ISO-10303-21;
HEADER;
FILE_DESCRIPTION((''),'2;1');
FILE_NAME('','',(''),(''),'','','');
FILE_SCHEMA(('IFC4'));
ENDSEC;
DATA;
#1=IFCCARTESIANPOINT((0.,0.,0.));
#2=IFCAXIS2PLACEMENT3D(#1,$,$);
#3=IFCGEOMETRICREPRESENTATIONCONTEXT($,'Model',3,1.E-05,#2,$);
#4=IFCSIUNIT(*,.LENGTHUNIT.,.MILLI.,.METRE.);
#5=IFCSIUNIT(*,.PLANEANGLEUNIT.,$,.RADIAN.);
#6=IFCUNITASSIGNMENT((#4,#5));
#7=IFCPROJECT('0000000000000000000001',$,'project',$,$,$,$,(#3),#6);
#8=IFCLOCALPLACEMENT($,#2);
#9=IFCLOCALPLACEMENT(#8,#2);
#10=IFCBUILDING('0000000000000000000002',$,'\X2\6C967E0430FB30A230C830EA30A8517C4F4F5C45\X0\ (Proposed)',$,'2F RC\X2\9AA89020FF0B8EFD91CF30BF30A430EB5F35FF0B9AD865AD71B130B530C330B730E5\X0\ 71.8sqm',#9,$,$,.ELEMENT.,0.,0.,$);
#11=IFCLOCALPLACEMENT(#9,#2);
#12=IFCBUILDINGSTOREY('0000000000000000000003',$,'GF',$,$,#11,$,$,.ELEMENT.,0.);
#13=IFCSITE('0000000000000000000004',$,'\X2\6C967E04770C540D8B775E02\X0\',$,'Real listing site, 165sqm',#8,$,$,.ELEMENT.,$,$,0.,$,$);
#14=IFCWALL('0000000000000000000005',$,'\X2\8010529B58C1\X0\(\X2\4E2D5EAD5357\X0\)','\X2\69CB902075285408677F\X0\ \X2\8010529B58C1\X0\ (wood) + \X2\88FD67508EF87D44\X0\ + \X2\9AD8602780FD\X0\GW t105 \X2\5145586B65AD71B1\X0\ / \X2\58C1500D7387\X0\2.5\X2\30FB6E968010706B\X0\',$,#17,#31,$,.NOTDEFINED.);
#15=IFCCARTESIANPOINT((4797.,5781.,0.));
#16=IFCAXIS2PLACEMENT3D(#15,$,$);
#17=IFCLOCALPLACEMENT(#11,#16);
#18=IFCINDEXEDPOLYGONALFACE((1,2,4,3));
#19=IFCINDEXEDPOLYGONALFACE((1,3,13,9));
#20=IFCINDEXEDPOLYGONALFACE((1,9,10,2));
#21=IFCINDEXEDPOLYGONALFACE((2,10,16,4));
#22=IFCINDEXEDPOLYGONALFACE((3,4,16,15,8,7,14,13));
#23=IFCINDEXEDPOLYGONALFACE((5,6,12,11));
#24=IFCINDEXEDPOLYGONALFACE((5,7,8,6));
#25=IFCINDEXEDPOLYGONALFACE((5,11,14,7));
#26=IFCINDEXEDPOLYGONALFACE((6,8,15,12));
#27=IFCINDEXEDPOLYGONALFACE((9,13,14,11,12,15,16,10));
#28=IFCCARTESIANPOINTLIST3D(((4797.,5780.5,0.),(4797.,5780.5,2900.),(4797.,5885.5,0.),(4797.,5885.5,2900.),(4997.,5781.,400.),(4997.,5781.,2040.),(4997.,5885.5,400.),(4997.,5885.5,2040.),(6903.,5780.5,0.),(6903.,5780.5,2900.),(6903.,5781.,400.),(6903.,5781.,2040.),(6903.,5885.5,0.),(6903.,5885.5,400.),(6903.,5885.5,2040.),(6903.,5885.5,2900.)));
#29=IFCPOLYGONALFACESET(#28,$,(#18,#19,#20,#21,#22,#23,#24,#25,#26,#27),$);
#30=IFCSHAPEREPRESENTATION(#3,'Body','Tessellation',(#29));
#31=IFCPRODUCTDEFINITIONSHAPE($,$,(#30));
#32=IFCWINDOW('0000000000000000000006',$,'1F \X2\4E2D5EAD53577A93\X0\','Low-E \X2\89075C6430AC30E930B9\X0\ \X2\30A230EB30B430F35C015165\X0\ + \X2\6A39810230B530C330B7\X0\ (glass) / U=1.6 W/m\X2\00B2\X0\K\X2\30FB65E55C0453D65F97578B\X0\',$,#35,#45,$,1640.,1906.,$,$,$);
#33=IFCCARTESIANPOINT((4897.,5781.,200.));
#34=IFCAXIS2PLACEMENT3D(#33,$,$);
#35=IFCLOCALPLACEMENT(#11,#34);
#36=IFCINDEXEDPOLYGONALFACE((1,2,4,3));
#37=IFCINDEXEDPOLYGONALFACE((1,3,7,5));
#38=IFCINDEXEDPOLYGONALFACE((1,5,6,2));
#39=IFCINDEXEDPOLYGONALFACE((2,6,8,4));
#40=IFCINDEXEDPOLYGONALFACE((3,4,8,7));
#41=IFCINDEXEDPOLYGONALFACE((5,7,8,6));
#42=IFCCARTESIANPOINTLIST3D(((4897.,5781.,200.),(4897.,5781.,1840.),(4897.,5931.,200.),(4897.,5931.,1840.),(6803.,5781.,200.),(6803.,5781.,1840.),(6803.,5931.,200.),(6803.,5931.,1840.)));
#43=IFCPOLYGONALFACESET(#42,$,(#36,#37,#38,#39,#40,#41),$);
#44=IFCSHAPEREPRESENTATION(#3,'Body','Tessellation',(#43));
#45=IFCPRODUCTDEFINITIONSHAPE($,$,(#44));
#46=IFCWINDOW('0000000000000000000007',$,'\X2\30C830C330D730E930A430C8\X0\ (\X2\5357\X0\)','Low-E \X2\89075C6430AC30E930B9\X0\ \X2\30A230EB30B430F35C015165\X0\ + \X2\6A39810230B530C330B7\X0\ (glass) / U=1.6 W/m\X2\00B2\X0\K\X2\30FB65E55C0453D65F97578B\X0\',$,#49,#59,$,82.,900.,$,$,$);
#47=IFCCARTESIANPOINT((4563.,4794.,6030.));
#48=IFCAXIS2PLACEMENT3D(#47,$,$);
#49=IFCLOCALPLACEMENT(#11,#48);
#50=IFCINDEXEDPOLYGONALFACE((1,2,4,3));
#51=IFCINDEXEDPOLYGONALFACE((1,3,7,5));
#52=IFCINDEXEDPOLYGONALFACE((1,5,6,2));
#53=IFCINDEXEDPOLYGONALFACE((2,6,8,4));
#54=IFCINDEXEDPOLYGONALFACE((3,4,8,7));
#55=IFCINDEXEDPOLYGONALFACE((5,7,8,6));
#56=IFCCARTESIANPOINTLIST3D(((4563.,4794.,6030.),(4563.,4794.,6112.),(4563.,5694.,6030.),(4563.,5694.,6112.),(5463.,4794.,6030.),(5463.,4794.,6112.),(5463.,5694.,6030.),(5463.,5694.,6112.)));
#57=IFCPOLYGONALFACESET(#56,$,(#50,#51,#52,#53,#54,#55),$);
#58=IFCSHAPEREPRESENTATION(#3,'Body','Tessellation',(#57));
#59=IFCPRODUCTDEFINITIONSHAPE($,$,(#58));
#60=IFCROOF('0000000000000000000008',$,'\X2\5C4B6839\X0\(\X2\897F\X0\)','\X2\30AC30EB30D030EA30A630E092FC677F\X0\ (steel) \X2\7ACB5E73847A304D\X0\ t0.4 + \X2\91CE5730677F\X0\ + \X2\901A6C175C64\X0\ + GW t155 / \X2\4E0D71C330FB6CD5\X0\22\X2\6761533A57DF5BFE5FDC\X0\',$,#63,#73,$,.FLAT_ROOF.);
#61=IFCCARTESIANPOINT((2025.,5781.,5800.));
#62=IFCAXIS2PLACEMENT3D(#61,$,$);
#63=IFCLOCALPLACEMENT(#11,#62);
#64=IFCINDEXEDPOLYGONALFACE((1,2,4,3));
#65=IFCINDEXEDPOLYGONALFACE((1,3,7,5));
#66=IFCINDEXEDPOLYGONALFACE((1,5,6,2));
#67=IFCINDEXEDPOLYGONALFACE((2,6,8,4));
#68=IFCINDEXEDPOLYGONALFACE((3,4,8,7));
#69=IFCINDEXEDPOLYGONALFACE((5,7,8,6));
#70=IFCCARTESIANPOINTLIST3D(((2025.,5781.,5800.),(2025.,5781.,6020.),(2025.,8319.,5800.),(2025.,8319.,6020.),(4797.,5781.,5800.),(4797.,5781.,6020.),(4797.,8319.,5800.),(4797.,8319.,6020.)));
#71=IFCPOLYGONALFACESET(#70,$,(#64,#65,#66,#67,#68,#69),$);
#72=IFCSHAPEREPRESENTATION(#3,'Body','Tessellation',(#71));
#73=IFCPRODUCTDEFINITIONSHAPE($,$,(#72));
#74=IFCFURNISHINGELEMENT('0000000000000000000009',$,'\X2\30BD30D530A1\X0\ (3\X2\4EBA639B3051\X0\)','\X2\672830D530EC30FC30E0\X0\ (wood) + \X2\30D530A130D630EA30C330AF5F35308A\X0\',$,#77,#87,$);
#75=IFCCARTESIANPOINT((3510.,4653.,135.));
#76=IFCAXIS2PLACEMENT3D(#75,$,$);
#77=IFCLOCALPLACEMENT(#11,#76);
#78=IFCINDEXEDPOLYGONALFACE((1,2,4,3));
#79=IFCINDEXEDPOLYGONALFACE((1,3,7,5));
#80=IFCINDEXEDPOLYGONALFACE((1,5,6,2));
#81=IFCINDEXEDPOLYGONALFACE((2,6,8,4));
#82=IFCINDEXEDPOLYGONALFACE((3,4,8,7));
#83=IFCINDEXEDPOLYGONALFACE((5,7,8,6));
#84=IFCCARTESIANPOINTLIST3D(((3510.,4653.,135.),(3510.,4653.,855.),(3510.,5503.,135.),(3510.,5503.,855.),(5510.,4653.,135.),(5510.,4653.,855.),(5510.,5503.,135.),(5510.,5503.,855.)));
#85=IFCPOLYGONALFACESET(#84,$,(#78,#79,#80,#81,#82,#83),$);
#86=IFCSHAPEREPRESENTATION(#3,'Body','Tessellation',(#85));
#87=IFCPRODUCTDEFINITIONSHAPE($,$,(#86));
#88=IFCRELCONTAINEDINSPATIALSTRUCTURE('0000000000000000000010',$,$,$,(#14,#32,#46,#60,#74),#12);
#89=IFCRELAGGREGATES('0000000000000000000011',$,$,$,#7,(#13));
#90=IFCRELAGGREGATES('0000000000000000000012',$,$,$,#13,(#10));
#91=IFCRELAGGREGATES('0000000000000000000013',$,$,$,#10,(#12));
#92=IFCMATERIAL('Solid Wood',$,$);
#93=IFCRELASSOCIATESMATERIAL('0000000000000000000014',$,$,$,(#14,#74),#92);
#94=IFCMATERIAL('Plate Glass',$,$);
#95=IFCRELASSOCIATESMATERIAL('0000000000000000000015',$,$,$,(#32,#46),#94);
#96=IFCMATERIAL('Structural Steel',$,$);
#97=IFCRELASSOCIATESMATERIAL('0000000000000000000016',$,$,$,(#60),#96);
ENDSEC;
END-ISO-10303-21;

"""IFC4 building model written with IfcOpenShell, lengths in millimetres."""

from ifc_helpers import new_model, si_unit, frame, frame_2d, origin, place, context, project, spatial, rectangle, extrude, material, element, fill, save


model = new_model("IFC4")

# Units and contexts
model_context = context("Model", 3, precision=1e-05, world=origin())
ifc_project = project(units=[si_unit("LENGTHUNIT", "METRE", prefix="MILLI"), si_unit("PLANEANGLEUNIT", "RADIAN")], contexts=[model_context])

# Site, building, storey
site_placement = place(None, origin())
site = spatial("IfcSite", under=ifc_project, at=site_placement, Name="沖縄県名護市", ObjectType="Real listing site, 165sqm", CompositionType="ELEMENT", RefElevation=0.0)
building_placement = place(site_placement, origin())
building = spatial("IfcBuilding", under=site, at=building_placement, Name="沖縄・アトリエ兼住居 (Proposed)", ObjectType="2F RC骨造＋軽量タイル張＋高断熱サッシュ 71.8sqm", CompositionType="ELEMENT", ElevationOfRefHeight=0.0, ElevationOfTerrain=0.0)
storey_placement = place(building_placement, origin())
storey = spatial("IfcBuildingStorey", under=building, at=storey_placement, Name="GF", CompositionType="ELEMENT", Elevation=0.0)

# Shared definitions
ifc_material_1 = material(Name="Solid Wood")

# Wall, opening, window
wall_1_placement = place(storey_placement, frame((4797.0, 5781.0, 0.0)))
wall_1 = element("IfcWall", 1, at=wall_1_placement, inside=storey, material=ifc_material_1, Name="耐力壁(中庭南)", Description="構造用合板 耐力壁 (wood) + 製材軸組 + 高性能GW t105 充填断熱 / 壁倍率2.5・準耐火", PredefinedType="NOTDEFINED", context=model_context, shape_type="SweptSolid", body=[
    extrude(rectangle(XDim=2106.0, YDim=105.0, at=frame_2d((1053.0, 52.0))), frame((4797.0, 5781.0, 0.0)), (0.0, 0.0, 1.0), 2900.0),
])
opening_placement = place(storey_placement, frame((4897.0, 5781.0, 200.0)))
opening = element("IfcOpeningElement", 2, at=opening_placement, cuts=wall_1, PredefinedType="NOTDEFINED", context=model_context, shape_type="SweptSolid", body=[
    extrude(rectangle(XDim=1906.0, YDim=150.0, at=frame_2d((953.0, 75.0))), frame((4897.0, 5781.0, 200.0)), (0.0, 0.0, 1.0), 1640.0),
])
ifc_material_2 = material(Name="Plate Glass")
window_1_placement = place(storey_placement, frame((4897.0, 5781.0, 200.0)))
window_1 = element("IfcWindow", 3, at=window_1_placement, inside=storey, material=ifc_material_2, Name="1F 中庭南窓", Description="Low-E 複層ガラス アルゴン封入 + 樹脂サッシ (glass) / U=1.6 W/m²K・日射取得型", OverallHeight=1640.0, OverallWidth=1906.0, context=model_context, shape_type="SweptSolid", body=[
    extrude(rectangle(XDim=1906.0, YDim=150.0, at=frame_2d((953.0, 75.0))), frame((4897.0, 5781.0, 200.0)), (0.0, 0.0, 1.0), 1640.0),
])
fill(opening, window_1)

# Window
window_2_placement = place(storey_placement, frame((4563.0, 4794.0, 6030.0)))
element("IfcWindow", 4, at=window_2_placement, inside=storey, material=ifc_material_2, Name="トップライト (南)", Description="Low-E 複層ガラス アルゴン封入 + 樹脂サッシ (glass) / U=1.6 W/m²K・日射取得型", OverallHeight=82.0, OverallWidth=900.0, context=model_context, shape_type="SweptSolid", body=[
    extrude(rectangle(XDim=900.0, YDim=900.0, at=frame_2d((450.0, 450.0))), frame((4563.0, 4794.0, 6030.0)), (0.0, 0.0, 1.0), 82.0),
])

# Roof
ifc_material_3 = material(Name="Structural Steel")
for number, where, name in (
    (5, (2025.0, 5781.0, 5800.0), "屋根(西)"),
):
    element("IfcRoof", number, at=place(storey_placement, frame(where)), inside=storey, material=ifc_material_3, Name=name, Description="ガルバリウム鋼板 (steel) 立平葺き t0.4 + 野地板 + 通気層 + GW t155 / 不燃・法22条区域対応", PredefinedType="FLAT_ROOF", context=model_context, shape_type="SweptSolid", body=[
        extrude(rectangle(XDim=2772.0, YDim=2538.0, at=frame_2d((1386.0, 1269.0))), frame((2025.0, 5781.0, 5800.0)), (0.0, 0.0, 1.0), 220.0),
    ])

# Furnishing element
furnishing_placement = place(storey_placement, frame((3510.0, 4653.0, 135.0)))
element("IfcFurnishingElement", 6, at=furnishing_placement, inside=storey, material=ifc_material_1, Name="ソファ (3人掛け)", Description="木フレーム (wood) + ファブリック張り", context=model_context, shape_type="SweptSolid", body=[
    extrude(rectangle(XDim=2000.0, YDim=850.0, at=frame_2d((1000.0, 425.0))), frame((3510.0, 4653.0, 135.0)), (0.0, 0.0, 1.0), 720.0),
])

save(model, "model.ifc")
